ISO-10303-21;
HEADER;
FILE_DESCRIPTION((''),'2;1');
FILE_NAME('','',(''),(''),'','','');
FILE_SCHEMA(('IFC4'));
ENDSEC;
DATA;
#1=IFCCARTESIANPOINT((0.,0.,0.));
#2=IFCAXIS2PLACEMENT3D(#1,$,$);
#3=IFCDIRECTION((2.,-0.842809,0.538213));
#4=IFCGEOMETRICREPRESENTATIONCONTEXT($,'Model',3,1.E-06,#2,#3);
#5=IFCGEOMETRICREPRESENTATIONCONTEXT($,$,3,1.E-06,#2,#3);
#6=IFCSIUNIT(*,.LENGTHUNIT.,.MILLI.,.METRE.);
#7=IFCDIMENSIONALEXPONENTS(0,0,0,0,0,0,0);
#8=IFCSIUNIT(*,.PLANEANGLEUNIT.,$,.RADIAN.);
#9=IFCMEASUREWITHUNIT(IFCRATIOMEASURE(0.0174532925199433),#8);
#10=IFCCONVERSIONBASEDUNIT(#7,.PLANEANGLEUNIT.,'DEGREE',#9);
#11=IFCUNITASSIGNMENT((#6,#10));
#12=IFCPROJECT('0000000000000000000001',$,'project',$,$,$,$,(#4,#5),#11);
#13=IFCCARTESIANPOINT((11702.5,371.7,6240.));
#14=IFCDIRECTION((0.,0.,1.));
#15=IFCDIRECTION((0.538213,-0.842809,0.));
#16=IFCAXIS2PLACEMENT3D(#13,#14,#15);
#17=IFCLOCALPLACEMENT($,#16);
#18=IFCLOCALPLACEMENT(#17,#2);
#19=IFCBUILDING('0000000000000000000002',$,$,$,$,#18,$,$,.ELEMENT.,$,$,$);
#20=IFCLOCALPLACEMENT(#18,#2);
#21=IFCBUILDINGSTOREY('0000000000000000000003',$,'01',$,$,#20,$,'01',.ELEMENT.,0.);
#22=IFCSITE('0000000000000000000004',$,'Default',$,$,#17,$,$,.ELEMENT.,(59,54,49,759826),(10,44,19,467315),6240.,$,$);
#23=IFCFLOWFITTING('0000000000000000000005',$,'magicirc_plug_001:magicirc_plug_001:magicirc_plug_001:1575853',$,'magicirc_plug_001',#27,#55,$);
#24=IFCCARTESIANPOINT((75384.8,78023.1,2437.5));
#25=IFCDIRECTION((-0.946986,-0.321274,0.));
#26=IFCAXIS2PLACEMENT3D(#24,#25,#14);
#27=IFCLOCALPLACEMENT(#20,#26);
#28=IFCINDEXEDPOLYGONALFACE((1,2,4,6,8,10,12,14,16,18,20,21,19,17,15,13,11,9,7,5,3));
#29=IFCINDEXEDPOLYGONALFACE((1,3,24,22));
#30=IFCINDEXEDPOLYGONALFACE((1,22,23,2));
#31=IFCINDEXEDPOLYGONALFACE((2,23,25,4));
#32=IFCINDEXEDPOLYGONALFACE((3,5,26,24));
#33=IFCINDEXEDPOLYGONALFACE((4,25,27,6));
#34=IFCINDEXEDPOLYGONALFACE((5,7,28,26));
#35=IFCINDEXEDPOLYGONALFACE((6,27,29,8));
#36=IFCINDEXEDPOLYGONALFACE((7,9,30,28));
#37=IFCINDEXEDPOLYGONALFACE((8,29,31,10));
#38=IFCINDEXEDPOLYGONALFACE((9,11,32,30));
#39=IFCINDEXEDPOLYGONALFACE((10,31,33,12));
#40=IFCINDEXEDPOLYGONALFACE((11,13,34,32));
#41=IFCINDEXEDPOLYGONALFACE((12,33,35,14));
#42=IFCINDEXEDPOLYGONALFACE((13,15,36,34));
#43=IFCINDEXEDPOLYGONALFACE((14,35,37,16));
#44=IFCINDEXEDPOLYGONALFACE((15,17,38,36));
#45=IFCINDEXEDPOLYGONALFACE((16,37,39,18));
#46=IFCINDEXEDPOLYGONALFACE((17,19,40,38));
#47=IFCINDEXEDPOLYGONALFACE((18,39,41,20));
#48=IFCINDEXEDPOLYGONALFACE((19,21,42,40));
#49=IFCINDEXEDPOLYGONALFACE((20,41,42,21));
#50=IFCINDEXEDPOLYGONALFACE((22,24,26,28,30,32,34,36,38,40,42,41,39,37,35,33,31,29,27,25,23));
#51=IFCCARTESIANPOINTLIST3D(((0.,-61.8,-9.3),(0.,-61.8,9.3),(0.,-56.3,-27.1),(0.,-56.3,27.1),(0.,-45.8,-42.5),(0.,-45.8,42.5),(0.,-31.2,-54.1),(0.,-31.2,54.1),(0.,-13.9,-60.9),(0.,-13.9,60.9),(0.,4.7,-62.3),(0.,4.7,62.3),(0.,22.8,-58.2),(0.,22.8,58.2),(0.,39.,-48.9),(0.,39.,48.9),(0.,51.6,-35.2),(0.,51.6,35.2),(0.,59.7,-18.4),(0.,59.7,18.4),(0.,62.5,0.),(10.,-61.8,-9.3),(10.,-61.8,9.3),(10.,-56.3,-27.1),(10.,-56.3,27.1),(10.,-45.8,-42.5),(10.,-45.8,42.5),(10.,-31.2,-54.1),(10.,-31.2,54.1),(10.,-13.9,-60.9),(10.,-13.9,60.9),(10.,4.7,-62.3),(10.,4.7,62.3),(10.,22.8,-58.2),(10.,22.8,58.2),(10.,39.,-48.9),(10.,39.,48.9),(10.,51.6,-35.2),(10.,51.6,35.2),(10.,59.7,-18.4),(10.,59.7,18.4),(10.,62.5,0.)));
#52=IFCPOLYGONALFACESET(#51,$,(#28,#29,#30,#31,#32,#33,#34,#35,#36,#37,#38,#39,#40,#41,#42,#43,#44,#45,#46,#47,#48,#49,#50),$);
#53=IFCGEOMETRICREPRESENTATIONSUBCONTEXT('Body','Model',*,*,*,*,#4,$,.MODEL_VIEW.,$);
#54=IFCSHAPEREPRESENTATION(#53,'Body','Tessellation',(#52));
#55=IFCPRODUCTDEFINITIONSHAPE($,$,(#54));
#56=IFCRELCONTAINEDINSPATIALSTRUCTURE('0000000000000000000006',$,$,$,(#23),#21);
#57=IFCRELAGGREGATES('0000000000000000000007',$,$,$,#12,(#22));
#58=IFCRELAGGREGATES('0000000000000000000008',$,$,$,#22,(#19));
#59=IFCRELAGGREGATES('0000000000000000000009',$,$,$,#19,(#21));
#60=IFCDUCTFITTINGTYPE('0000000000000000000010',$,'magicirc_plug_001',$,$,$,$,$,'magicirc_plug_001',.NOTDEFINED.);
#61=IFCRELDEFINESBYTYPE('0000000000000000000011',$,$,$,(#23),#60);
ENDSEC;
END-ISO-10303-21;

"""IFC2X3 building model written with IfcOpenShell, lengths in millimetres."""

from ifc_helpers import new_model, entity, si_unit, converted_unit, direction, frame, frame_2d, origin, place, context, subcontext, project, spatial, circle, extrude, source, transform, mapped, type_object, type_shapes, element, save


model = new_model("IFC2X3")

# Units and contexts
model_context = context("Model", 3, precision=1e-06, world=origin(), true_north=direction((2.0, -0.842809, 0.538213)))
context_of_model = context(None, 3, precision=1e-06, world=origin(), true_north=direction((2.0, -0.842809, 0.538213)))
body_context = subcontext(model_context, "Body", "Model", "MODEL_VIEW")
ifc_project = project(units=[si_unit("LENGTHUNIT", "METRE", prefix="MILLI"), converted_unit("PLANEANGLEUNIT", "DEGREE", entity("IfcRatioMeasure", 0.0174532925199433), si_unit("PLANEANGLEUNIT", "RADIAN"), dimensions=[0, 0, 0, 0, 0, 0, 0])], contexts=[model_context, context_of_model])

# Site, building, storey
site_placement = place(None, frame((11702.5, 371.7, 6240.0), z_axis=(0.0, 0.0, 1.0), x_axis=(0.538213, -0.842809, 0.0)))
site = spatial("IfcSite", under=ifc_project, at=site_placement, Name="Default", CompositionType="ELEMENT", RefLatitude=(59, 54, 49, 759826), RefLongitude=(10, 44, 19, 467315), RefElevation=6240.0)
building_placement = place(site_placement, origin())
building = spatial("IfcBuilding", under=site, at=building_placement, CompositionType="ELEMENT")
storey_placement = place(building_placement, origin())
storey = spatial("IfcBuildingStorey", under=building, at=storey_placement, Name="01", LongName="01", CompositionType="ELEMENT", Elevation=0.0)

# Flow fitting
duct_fitting_type_1 = type_object("IfcDuctFittingType", Name="magicirc_plug_001", ElementType="magicirc_plug_001", PredefinedType="NOTDEFINED")
shared_shape_1 = source(origin(), body_context, "Body", "SweptSolid", [
    extrude(circle(Radius=62.5, at=frame_2d((0.0, 0.0), x_axis=(1.0, 0.0))), frame((0.0, 0.0, 0.0), z_axis=(1.0, 0.0, 0.0), x_axis=(0.0, 1.0, 0.0)), (0.0, 0.0, 1.0), 10.0),
])
type_shapes(duct_fitting_type_1, [shared_shape_1])
for number, where, z_axis, x_axis, name in (
    (1, (75384.8, 78023.1, 2437.5), (-0.946986, -0.321274, 0.0), (0.0, 0.0, 1.0), "magicirc_plug_001:magicirc_plug_001:magicirc_plug_001:1575853"),
):
    element("IfcFlowFitting", number, at=place(storey_placement, frame(where, z_axis=z_axis, x_axis=x_axis)), inside=storey, type_object=duct_fitting_type_1, Name=name, ObjectType="magicirc_plug_001", context=body_context, shape_type="MappedRepresentation", body=[
        mapped(shared_shape_1, transform((0.0, 0.0, 0.0), scale=1.0)),
    ])

save(model, "model.ifc")
